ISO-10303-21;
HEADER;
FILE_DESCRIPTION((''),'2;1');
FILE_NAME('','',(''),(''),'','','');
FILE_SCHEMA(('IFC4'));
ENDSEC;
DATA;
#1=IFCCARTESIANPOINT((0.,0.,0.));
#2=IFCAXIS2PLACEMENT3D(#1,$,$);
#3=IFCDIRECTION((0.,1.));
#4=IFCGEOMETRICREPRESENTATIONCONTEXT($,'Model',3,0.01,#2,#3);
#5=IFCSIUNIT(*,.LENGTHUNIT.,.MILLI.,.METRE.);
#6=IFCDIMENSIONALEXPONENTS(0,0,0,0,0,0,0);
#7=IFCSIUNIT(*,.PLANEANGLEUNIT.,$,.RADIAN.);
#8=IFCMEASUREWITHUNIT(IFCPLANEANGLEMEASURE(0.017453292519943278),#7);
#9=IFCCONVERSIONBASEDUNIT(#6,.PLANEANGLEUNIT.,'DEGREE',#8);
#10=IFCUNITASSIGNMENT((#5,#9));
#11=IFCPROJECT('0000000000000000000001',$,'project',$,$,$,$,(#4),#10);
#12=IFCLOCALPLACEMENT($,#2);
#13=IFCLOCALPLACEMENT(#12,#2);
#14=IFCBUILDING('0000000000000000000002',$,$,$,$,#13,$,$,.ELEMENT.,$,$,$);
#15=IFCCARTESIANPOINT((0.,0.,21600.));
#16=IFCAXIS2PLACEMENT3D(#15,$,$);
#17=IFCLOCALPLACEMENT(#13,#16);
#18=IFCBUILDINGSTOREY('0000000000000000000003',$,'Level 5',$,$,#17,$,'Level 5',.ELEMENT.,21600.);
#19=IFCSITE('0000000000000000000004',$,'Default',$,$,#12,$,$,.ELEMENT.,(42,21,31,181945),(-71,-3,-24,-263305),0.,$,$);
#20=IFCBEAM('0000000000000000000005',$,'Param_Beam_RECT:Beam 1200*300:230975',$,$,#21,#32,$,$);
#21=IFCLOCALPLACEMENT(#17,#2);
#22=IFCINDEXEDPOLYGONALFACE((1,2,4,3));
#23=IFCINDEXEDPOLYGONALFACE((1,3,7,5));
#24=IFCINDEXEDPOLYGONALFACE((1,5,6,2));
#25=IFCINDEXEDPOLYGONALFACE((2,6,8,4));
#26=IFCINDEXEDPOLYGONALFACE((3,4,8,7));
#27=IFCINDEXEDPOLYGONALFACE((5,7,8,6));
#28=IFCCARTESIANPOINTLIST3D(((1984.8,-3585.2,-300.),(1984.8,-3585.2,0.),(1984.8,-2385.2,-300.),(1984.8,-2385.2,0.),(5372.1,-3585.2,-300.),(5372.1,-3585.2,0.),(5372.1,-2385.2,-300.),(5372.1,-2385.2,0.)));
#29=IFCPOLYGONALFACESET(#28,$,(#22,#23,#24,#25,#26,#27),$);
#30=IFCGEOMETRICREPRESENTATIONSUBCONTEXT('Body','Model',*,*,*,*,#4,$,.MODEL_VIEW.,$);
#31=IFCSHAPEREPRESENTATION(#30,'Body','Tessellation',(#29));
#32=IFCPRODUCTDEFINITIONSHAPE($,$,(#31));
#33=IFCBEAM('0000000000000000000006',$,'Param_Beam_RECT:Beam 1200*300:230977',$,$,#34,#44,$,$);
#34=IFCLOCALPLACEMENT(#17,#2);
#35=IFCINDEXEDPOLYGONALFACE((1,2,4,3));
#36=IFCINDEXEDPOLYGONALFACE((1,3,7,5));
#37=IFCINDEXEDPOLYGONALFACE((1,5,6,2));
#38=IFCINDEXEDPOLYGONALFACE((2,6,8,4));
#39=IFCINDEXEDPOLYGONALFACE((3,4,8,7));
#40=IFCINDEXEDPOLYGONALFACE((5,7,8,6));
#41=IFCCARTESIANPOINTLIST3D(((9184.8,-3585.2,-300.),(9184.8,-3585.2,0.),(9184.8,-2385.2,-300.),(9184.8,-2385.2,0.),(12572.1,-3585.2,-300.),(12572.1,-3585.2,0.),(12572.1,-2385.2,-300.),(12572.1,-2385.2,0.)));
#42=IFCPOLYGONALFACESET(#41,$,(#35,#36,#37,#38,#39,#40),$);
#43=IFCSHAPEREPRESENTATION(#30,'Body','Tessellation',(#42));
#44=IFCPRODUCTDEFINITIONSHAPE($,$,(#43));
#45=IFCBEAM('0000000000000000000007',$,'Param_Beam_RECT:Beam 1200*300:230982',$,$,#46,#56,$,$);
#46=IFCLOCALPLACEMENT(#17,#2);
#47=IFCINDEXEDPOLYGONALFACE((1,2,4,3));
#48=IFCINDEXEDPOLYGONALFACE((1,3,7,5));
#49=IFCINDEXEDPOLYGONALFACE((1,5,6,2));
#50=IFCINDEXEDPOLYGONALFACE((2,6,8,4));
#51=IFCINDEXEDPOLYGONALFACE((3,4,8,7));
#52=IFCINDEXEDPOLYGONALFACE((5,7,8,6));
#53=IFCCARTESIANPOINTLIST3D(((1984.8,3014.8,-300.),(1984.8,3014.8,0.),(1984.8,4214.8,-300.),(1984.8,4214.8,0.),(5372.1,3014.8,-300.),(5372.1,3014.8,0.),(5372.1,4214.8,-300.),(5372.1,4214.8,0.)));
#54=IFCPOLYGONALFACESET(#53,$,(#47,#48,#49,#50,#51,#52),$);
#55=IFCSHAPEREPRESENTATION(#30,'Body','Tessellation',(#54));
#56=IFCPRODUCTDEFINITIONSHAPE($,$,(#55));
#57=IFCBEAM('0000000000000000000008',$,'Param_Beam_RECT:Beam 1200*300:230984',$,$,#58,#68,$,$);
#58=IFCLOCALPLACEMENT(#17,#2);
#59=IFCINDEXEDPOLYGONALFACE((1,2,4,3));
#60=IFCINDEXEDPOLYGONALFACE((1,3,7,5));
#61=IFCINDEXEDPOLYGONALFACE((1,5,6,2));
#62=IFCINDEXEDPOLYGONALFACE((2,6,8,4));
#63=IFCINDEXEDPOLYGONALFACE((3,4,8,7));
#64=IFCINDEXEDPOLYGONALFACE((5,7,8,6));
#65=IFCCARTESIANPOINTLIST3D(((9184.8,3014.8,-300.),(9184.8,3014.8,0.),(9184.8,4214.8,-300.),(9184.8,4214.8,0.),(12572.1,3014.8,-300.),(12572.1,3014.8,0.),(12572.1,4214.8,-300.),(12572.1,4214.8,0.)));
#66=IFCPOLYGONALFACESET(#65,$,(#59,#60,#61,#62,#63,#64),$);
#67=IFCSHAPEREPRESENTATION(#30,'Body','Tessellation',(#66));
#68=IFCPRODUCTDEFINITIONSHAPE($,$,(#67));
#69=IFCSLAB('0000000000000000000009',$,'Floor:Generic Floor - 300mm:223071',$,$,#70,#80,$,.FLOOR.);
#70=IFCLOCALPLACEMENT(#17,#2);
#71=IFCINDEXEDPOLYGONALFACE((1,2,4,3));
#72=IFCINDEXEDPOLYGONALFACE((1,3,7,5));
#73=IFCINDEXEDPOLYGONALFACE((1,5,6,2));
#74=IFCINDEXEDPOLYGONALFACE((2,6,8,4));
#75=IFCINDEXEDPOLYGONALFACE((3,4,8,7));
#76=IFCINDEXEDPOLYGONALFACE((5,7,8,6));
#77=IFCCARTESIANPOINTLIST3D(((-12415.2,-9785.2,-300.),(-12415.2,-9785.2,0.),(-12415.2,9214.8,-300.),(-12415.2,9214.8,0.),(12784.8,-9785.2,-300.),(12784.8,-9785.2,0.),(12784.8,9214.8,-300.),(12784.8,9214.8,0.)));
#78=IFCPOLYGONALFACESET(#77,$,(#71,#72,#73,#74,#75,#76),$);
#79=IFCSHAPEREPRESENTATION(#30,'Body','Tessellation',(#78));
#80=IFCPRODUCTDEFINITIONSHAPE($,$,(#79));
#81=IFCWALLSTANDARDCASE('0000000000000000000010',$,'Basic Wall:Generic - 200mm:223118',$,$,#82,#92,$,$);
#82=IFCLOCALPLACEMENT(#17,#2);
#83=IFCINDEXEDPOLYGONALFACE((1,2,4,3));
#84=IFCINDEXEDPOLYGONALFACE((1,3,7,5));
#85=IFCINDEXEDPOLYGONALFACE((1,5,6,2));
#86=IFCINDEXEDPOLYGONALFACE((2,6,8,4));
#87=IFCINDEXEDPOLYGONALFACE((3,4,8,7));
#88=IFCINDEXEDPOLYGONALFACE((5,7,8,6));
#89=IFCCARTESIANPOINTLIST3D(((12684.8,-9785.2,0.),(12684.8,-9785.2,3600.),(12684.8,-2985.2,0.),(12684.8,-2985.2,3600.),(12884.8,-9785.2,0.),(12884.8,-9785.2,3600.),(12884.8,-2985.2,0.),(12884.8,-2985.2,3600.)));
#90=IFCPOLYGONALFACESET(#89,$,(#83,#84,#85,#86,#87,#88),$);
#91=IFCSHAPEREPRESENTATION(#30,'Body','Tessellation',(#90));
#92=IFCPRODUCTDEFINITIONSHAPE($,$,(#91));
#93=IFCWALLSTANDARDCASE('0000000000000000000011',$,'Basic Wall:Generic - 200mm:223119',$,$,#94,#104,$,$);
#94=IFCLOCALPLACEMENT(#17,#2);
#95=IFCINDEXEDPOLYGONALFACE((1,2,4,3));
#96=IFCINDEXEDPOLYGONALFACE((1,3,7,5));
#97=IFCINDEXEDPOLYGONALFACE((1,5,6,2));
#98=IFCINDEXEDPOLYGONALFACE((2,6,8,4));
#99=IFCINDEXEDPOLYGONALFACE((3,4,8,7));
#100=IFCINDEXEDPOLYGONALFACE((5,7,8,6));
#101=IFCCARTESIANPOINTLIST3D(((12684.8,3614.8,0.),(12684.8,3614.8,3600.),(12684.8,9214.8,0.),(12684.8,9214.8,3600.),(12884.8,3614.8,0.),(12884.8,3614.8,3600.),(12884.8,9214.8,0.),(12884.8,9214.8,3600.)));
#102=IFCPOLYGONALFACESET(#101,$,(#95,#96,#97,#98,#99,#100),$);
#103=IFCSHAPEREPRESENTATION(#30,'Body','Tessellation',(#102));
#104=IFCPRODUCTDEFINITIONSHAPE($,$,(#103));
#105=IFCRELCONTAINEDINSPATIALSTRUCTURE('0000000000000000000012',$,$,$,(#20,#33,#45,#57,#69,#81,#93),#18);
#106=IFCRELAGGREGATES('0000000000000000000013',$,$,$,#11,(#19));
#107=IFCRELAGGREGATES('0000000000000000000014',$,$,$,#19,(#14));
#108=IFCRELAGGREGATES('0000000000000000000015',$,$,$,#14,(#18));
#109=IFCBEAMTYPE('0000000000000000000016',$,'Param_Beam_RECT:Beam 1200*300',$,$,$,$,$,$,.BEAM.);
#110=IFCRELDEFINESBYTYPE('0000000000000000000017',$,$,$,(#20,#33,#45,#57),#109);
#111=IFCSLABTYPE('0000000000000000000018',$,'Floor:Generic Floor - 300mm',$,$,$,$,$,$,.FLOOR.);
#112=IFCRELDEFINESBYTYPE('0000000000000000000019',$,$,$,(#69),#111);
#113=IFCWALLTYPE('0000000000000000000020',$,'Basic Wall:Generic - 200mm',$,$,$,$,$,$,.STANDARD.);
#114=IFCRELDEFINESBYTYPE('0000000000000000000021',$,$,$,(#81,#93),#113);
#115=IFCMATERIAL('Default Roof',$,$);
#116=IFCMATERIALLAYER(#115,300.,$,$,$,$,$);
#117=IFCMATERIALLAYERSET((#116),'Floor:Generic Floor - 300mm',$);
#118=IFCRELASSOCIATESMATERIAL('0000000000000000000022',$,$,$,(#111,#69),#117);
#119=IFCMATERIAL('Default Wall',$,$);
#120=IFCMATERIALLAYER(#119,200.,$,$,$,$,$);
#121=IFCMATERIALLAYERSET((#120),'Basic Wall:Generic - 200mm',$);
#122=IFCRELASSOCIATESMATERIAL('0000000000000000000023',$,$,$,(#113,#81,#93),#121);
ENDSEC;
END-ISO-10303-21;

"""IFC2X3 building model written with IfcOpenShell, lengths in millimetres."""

from ifc_helpers import new_model, entity, si_unit, converted_unit, direction, frame, frame_2d, origin, origin_2d_with_axis, place, context, subcontext, project, spatial, rectangle, extrude, material, layer, layer_set, layer_usage, type_object, element, save


model = new_model("IFC2X3")

# Units and contexts
model_context = context("Model", 3, precision=0.01, world=origin(), true_north=direction((0.0, 1.0)))
body_context = subcontext(model_context, "Body", "Model", "MODEL_VIEW")
ifc_project = project(units=[si_unit("LENGTHUNIT", "METRE", prefix="MILLI"), converted_unit("PLANEANGLEUNIT", "DEGREE", entity("IfcPlaneAngleMeasure", 0.017453292519943278), si_unit("PLANEANGLEUNIT", "RADIAN"), dimensions=[0, 0, 0, 0, 0, 0, 0])], contexts=[model_context])

# Site, building, storey
site_placement = place(None, origin())
site = spatial("IfcSite", under=ifc_project, at=site_placement, Name="Default", CompositionType="ELEMENT", RefLatitude=(42, 21, 31, 181945), RefLongitude=(-71, -3, -24, -263305), RefElevation=0.0)
building_placement = place(site_placement, origin())
building = spatial("IfcBuilding", under=site, at=building_placement, CompositionType="ELEMENT")
storey_placement = place(building_placement, frame((0.0, 0.0, 21600.0)))
storey = spatial("IfcBuildingStorey", under=building, at=storey_placement, Name="Level 5", LongName="Level 5", CompositionType="ELEMENT", Elevation=21600.0)

# Beams
beam_type_1 = type_object("IfcBeamType", Name="Param_Beam_RECT:Beam 1200*300", PredefinedType="BEAM")
beam_1_placement = place(storey_placement, frame((1984.8, -2985.2, 0.0)))
element("IfcBeam", 1, at=beam_1_placement, inside=storey, type_object=beam_type_1, Name="Param_Beam_RECT:Beam 1200*300:230975", context=body_context, shape_type="SweptSolid", body=[
    extrude(rectangle(XDim=300.0, YDim=1200.0, at=frame_2d((0.0, 0.0), x_axis=(1.0, 0.0))), frame((0.0, 0.0, -150.0), z_axis=(1.0, 0.0, 0.0), x_axis=(0.0, 0.0, -1.0)), (0.0, 0.0, 1.0), 3387.3),
])
beam_2_placement = place(storey_placement, frame((9184.8, -2985.2, 0.0)))
element("IfcBeam", 2, at=beam_2_placement, inside=storey, type_object=beam_type_1, Name="Param_Beam_RECT:Beam 1200*300:230977", context=body_context, shape_type="SweptSolid", body=[
    extrude(rectangle(XDim=300.0, YDim=1200.0, at=frame_2d((0.0, 0.0), x_axis=(1.0, 0.0))), frame((0.0, 0.0, -150.0), z_axis=(1.0, 0.0, 0.0), x_axis=(0.0, 0.0, -1.0)), (0.0, 0.0, 1.0), 3387.3),
])
beam_3_placement = place(storey_placement, frame((1984.8, 3614.8, 0.0)))
element("IfcBeam", 3, at=beam_3_placement, inside=storey, type_object=beam_type_1, Name="Param_Beam_RECT:Beam 1200*300:230982", context=body_context, shape_type="SweptSolid", body=[
    extrude(rectangle(XDim=300.0, YDim=1200.0, at=frame_2d((0.0, 0.0), x_axis=(1.0, 0.0))), frame((0.0, 0.0, -150.0), z_axis=(1.0, 0.0, 0.0), x_axis=(0.0, 0.0, -1.0)), (0.0, 0.0, 1.0), 3387.3),
])
beam_4_placement = place(storey_placement, frame((9184.8, 3614.8, 0.0)))
element("IfcBeam", 4, at=beam_4_placement, inside=storey, type_object=beam_type_1, Name="Param_Beam_RECT:Beam 1200*300:230984", context=body_context, shape_type="SweptSolid", body=[
    extrude(rectangle(XDim=300.0, YDim=1200.0, at=frame_2d((0.0, 0.0), x_axis=(1.0, 0.0))), frame((0.0, 0.0, -150.0), z_axis=(1.0, 0.0, 0.0), x_axis=(0.0, 0.0, -1.0)), (0.0, 0.0, 1.0), 3387.3),
])

# Slab
ifc_material_1 = material(Name="Default Roof")
ifc_layer_1 = layer(ifc_material_1, 300.0)
ifc_layer_set_1 = layer_set([ifc_layer_1], Name="Floor:Generic Floor - 300mm")
ifc_layer_usage_1 = layer_usage(ifc_layer_set_1, "AXIS3", "POSITIVE", 0.0)
slab_type = type_object("IfcSlabType", Name="Floor:Generic Floor - 300mm", PredefinedType="FLOOR", material=ifc_layer_set_1)
slab_placement = place(storey_placement, origin())
element("IfcSlab", 5, at=slab_placement, inside=storey, type_object=slab_type, material=ifc_layer_usage_1, Name="Floor:Generic Floor - 300mm:223071", PredefinedType="FLOOR", context=body_context, shape_type="SweptSolid", body=[
    extrude(rectangle(XDim=19000.0, YDim=25200.0, at=origin_2d_with_axis()), frame((184.8, -285.2, 0.0), z_axis=(0.0, 0.0, -1.0), x_axis=(0.0, 1.0, 0.0)), (0.0, 0.0, 1.0), 300.0),
])

# Walls
ifc_material_2 = material(Name="Default Wall")
ifc_layer_2 = layer(ifc_material_2, 200.0)
ifc_layer_set_2 = layer_set([ifc_layer_2], Name="Basic Wall:Generic - 200mm")
ifc_layer_usage_2 = layer_usage(ifc_layer_set_2, "AXIS2", "NEGATIVE", 100.0)
wall_type = type_object("IfcWallType", Name="Basic Wall:Generic - 200mm", PredefinedType="STANDARD", material=ifc_layer_set_2)
wall_1_placement = place(storey_placement, frame((12784.8, -9785.2, 0.0), z_axis=(0.0, 0.0, 1.0), x_axis=(0.0, 1.0, 0.0)))
element("IfcWallStandardCase", 6, at=wall_1_placement, inside=storey, type_object=wall_type, material=ifc_layer_usage_2, Name="Basic Wall:Generic - 200mm:223118", context=body_context, shape_type="SweptSolid", body=[
    extrude(rectangle(XDim=6800.0, YDim=200.0, at=frame_2d((3400.0, 0.0), x_axis=(-1.0, 0.0))), origin(), (0.0, 0.0, 1.0), 3600.0),
])
ifc_layer_usage_3 = layer_usage(ifc_layer_set_2, "AXIS2", "NEGATIVE", 100.0)
wall_2_placement = place(storey_placement, frame((12784.8, 3614.8, 0.0), z_axis=(0.0, 0.0, 1.0), x_axis=(0.0, 1.0, 0.0)))
element("IfcWallStandardCase", 7, at=wall_2_placement, inside=storey, type_object=wall_type, material=ifc_layer_usage_3, Name="Basic Wall:Generic - 200mm:223119", context=body_context, shape_type="SweptSolid", body=[
    extrude(rectangle(XDim=5600.0, YDim=200.0, at=frame_2d((2800.0, 0.0), x_axis=(-1.0, 0.0))), origin(), (0.0, 0.0, 1.0), 3600.0),
])

save(model, "model.ifc")
